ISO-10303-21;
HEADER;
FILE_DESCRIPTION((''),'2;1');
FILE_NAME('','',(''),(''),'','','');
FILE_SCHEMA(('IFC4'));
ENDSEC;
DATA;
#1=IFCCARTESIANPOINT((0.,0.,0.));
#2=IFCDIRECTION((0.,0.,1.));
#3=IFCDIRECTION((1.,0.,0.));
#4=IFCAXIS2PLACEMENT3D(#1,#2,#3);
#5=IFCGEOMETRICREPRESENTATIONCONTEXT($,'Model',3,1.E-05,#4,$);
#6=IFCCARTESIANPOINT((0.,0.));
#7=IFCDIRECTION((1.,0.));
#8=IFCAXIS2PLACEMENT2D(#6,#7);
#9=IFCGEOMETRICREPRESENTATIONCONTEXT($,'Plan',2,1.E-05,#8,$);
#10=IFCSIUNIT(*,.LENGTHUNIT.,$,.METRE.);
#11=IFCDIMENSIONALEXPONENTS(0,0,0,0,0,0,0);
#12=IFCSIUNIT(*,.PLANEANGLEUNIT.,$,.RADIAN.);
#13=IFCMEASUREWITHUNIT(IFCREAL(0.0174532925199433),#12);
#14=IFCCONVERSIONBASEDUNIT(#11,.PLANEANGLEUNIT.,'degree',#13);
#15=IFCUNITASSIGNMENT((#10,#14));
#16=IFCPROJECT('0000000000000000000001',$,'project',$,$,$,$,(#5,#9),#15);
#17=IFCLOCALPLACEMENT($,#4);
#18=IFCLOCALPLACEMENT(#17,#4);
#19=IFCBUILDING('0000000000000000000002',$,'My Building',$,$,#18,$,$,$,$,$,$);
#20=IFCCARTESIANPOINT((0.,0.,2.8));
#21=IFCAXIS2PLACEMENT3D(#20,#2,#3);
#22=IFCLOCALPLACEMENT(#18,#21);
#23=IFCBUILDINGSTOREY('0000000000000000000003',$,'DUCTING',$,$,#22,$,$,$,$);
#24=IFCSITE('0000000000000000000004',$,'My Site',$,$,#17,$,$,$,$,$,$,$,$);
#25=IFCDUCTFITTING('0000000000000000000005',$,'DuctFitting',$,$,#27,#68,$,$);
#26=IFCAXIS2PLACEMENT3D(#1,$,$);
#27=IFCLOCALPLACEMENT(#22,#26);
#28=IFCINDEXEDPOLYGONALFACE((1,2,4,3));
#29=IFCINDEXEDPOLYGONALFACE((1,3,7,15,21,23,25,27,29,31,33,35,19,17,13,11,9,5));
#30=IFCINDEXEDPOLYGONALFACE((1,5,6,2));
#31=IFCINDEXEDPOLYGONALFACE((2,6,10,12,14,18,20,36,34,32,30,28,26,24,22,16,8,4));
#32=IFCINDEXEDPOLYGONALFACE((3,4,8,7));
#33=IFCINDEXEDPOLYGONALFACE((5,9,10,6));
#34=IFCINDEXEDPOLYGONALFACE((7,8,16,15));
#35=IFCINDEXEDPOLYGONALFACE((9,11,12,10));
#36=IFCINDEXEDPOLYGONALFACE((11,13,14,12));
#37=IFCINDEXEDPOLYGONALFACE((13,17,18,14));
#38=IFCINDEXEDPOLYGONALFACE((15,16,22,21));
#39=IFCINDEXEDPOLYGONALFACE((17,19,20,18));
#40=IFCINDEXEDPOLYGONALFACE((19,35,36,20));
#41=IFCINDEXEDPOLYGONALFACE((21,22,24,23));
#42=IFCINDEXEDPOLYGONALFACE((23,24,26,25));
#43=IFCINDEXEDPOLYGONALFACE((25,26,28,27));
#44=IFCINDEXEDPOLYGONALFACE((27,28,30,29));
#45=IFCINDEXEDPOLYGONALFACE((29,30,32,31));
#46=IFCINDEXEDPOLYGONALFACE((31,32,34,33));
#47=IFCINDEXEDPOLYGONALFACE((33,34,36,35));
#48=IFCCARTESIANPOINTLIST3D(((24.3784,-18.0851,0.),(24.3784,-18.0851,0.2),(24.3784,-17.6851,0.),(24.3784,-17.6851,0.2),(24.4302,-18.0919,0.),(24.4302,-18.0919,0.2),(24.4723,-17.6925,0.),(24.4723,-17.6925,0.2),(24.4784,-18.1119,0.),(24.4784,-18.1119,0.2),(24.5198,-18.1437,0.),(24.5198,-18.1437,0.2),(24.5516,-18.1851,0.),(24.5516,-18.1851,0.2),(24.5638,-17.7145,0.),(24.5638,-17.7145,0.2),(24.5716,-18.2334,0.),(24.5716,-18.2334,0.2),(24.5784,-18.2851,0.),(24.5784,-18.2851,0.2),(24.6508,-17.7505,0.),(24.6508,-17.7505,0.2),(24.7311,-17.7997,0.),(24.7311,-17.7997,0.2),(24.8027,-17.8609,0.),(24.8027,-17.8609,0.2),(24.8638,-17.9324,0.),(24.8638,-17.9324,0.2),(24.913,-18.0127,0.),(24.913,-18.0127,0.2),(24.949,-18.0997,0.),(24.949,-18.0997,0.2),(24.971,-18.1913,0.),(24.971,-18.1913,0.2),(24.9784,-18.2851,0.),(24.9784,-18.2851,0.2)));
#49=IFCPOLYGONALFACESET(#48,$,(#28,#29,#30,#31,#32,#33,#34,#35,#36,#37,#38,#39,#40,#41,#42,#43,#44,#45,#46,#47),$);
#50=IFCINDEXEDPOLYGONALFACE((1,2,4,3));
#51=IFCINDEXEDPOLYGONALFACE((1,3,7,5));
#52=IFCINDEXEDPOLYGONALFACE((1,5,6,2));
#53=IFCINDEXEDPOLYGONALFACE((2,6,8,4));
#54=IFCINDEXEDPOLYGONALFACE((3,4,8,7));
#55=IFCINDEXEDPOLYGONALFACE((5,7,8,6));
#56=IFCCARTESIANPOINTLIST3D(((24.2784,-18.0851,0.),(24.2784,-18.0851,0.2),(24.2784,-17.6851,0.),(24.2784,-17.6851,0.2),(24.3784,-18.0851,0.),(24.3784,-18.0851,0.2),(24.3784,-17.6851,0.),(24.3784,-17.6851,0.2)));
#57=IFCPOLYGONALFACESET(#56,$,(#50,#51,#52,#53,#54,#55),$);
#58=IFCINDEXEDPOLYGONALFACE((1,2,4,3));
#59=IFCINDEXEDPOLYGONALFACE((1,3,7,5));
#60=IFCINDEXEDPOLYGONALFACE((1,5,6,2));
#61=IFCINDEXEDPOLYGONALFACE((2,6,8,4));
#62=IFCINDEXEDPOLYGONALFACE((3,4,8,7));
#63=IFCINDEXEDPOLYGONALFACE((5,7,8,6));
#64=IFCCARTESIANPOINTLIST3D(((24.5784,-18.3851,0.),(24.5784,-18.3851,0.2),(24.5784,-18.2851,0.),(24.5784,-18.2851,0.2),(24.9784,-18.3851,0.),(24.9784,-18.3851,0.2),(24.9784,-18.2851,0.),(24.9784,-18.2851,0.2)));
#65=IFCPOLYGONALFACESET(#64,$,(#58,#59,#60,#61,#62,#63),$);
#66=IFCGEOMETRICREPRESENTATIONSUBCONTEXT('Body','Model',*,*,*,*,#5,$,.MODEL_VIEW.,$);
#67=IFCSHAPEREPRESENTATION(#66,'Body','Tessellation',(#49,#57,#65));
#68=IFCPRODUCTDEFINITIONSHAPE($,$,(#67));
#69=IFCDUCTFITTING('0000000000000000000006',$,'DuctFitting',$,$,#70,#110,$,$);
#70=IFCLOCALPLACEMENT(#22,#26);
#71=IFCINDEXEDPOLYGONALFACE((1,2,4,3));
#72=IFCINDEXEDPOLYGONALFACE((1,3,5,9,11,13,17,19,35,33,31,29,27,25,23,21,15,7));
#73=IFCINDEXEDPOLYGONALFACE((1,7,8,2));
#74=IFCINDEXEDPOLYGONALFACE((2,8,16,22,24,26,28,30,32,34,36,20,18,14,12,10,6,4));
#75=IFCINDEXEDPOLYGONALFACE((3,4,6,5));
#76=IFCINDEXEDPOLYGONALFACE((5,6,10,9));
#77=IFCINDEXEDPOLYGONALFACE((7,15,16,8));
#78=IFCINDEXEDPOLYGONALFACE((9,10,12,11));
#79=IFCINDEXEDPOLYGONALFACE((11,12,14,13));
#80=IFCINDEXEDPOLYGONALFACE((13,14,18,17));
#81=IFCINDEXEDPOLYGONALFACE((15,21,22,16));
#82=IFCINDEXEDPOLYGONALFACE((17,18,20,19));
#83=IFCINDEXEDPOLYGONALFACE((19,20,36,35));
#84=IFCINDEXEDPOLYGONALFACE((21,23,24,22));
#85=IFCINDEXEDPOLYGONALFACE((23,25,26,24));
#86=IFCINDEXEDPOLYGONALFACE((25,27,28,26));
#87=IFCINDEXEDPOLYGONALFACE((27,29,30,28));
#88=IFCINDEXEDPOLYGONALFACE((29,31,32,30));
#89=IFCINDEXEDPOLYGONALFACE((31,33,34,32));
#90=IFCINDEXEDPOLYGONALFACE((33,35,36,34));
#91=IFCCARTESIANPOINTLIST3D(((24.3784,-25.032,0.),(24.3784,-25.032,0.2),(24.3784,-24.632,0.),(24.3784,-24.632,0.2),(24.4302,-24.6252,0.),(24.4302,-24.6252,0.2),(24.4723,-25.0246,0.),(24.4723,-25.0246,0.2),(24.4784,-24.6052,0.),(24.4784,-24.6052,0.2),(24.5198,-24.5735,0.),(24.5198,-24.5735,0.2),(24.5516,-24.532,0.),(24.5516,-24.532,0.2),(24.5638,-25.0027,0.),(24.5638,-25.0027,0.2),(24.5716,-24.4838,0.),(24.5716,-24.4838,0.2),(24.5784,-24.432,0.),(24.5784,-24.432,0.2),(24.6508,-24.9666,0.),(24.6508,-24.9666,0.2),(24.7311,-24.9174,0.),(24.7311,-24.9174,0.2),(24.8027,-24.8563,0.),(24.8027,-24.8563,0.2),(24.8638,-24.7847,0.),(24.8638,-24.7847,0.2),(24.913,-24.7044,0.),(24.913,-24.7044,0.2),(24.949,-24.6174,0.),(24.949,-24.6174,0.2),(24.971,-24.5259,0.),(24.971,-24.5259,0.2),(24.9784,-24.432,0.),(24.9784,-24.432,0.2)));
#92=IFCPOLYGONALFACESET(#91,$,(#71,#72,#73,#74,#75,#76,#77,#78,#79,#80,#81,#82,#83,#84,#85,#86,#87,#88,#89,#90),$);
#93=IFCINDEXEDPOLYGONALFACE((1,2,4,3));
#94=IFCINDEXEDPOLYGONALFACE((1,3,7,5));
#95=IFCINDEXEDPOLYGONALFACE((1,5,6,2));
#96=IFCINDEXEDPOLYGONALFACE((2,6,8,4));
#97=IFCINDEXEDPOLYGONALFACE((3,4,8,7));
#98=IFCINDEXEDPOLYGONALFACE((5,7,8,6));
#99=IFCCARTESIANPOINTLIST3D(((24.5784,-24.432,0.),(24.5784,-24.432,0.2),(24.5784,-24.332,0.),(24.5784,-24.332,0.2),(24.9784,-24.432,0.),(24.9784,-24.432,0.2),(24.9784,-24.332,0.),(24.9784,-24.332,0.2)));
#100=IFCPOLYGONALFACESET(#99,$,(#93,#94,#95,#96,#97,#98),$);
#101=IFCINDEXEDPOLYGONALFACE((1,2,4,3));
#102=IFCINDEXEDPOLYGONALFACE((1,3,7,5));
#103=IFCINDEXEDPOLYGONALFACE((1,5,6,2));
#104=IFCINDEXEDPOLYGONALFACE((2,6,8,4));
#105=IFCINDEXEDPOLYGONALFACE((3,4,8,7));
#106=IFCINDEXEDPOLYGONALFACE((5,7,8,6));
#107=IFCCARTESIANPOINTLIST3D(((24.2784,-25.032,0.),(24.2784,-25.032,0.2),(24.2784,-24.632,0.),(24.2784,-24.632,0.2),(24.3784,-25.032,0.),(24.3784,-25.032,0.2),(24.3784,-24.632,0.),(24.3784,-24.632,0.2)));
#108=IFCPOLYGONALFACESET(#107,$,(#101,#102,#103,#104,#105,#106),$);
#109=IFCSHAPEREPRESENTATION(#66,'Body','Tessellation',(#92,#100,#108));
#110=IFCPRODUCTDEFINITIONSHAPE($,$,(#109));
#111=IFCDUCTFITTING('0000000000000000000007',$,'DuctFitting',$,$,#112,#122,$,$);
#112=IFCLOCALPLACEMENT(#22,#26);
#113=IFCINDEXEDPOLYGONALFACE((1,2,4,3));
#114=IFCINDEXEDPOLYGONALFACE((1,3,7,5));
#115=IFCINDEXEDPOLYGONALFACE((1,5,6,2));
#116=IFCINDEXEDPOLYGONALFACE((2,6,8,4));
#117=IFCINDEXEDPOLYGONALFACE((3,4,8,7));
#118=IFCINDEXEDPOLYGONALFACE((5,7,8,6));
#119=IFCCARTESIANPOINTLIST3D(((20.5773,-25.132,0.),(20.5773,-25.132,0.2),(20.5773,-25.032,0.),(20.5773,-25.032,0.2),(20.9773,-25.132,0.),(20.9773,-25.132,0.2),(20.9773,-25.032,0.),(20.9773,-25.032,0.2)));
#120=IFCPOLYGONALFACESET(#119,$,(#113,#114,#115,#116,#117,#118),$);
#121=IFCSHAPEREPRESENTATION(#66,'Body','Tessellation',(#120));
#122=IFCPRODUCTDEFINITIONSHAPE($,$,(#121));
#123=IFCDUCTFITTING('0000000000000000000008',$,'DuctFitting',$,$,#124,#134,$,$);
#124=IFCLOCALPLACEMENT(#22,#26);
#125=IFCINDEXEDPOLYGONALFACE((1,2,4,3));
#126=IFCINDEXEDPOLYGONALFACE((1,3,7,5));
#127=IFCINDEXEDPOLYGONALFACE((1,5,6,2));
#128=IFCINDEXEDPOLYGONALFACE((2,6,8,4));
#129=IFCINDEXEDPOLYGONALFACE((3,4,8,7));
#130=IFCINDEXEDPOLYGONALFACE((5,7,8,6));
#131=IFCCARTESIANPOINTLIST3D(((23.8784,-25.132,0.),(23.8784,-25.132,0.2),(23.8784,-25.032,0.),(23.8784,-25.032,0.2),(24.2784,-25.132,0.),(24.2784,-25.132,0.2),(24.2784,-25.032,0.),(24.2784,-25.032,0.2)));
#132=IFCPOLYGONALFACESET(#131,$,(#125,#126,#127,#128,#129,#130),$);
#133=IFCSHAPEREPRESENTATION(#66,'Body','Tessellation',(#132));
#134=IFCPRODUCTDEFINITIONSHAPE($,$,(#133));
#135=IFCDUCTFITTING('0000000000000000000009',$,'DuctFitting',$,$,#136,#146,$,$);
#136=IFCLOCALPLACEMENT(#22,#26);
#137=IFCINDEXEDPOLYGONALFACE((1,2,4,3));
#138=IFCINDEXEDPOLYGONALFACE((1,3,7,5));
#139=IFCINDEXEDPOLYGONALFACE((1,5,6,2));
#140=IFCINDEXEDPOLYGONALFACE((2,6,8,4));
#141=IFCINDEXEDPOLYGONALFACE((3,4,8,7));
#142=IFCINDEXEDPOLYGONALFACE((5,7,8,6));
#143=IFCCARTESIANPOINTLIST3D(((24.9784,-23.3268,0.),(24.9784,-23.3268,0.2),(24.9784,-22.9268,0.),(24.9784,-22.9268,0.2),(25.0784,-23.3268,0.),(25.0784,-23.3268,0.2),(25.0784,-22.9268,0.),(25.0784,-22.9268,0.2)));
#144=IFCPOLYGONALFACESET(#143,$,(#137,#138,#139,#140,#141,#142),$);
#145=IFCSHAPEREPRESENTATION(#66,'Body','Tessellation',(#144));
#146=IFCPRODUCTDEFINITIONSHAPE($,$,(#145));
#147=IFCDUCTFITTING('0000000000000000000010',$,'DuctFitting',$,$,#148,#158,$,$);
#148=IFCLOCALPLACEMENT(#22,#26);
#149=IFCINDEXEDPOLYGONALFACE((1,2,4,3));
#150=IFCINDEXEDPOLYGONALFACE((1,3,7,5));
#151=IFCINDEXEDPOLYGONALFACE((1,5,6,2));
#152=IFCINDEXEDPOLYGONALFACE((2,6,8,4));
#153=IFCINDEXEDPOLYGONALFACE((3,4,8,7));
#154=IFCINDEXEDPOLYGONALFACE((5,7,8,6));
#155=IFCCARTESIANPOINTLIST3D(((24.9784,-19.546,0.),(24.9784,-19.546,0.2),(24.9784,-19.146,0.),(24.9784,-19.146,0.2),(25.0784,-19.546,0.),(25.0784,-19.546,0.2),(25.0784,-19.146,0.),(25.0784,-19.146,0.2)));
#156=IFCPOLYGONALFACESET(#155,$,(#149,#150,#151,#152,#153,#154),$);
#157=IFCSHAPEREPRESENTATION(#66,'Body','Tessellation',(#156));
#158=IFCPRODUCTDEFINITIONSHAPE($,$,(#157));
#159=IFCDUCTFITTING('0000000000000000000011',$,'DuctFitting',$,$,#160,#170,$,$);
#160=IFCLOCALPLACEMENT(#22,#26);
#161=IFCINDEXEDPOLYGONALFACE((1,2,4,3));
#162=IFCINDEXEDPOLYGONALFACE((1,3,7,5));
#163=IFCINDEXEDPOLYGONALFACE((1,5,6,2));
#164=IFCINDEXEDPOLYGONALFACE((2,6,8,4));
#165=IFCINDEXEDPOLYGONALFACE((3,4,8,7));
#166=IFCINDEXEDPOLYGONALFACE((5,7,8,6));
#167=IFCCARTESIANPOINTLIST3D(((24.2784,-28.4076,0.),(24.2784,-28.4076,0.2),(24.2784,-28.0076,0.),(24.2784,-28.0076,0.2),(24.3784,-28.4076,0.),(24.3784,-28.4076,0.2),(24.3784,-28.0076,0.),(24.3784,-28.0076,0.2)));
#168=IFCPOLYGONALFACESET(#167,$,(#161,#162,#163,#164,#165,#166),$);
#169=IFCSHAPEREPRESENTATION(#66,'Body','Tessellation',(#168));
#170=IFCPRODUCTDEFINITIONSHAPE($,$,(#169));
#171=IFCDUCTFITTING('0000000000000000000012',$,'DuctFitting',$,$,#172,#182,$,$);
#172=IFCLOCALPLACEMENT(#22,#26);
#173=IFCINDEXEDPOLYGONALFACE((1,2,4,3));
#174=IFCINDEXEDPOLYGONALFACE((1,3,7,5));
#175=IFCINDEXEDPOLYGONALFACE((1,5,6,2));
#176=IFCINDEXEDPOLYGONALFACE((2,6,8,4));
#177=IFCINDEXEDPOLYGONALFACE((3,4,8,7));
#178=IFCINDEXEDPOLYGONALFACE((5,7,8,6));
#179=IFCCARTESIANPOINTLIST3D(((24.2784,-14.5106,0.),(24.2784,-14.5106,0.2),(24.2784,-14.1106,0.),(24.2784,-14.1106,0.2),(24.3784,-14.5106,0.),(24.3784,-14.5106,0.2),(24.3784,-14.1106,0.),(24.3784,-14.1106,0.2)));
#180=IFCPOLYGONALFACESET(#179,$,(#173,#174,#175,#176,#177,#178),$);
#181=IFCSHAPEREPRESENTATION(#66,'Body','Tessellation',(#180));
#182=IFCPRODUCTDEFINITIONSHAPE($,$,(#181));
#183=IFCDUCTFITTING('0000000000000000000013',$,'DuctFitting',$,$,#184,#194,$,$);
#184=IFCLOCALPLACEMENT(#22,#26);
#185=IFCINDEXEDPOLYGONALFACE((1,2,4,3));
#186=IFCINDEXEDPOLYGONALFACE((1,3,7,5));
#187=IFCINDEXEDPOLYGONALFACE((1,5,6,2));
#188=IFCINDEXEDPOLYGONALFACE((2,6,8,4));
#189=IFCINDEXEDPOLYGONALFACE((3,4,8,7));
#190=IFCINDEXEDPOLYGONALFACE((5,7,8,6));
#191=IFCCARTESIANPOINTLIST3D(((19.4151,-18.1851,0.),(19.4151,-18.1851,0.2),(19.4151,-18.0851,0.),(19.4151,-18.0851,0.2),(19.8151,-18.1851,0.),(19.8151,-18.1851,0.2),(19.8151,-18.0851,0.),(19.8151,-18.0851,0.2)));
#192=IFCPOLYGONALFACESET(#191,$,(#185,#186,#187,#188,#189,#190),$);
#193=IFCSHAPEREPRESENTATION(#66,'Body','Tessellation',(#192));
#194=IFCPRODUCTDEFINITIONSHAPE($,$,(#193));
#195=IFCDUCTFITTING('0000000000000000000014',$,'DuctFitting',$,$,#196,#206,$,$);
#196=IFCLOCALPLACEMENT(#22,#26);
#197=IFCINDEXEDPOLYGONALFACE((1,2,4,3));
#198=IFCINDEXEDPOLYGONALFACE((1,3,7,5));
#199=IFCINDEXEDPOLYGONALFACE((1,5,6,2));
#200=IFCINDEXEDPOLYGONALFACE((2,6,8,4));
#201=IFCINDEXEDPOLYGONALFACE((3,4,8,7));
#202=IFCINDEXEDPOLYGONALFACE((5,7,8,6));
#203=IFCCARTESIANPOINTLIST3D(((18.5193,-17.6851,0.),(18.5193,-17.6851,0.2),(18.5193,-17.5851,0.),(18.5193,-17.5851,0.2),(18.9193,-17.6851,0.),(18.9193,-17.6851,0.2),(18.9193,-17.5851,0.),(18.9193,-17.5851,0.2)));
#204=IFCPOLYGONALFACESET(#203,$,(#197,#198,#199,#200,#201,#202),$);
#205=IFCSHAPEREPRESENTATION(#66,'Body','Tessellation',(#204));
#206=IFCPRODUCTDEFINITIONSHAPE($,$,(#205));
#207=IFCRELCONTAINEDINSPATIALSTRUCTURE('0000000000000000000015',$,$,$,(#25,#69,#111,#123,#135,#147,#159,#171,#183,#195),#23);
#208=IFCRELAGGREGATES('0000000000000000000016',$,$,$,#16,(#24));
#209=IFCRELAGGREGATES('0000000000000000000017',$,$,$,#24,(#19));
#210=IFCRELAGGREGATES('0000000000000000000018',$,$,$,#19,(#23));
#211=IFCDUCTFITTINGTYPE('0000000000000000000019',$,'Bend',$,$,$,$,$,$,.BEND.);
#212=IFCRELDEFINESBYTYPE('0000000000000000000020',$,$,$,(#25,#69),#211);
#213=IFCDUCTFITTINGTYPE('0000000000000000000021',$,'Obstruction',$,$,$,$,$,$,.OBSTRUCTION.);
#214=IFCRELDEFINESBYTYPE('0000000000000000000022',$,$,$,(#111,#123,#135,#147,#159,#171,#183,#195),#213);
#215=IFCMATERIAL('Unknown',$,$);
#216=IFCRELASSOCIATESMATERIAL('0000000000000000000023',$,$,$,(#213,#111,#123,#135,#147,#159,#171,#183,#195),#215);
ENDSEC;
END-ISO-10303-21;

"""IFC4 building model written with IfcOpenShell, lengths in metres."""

from ifc_helpers import new_model, entity, si_unit, converted_unit, frame, origin_with_axes, origin_2d_with_axis, place, context, subcontext, project, spatial, line, arc, indexed_curve, rectangle, outline, extrude, source, transform, mapped, material, material_profile, profile_set, profile_usage, type_object, type_shapes, element, save


model = new_model("IFC4")

# Units and contexts
model_context = context("Model", 3, precision=1e-05, world=origin_with_axes())
plan_context = context("Plan", 2, precision=1e-05, world=origin_2d_with_axis())
body_context = subcontext(model_context, "Body", "Model", "MODEL_VIEW")
ifc_project = project(units=[si_unit("LENGTHUNIT", "METRE"), converted_unit("PLANEANGLEUNIT", "degree", entity("IfcReal", 0.0174532925199433), si_unit("PLANEANGLEUNIT", "RADIAN"), dimensions=[0, 0, 0, 0, 0, 0, 0])], contexts=[model_context, plan_context])

# Site, building, storey
site_placement = place(None, origin_with_axes())
site = spatial("IfcSite", under=ifc_project, at=site_placement, Name="My Site")
building_placement = place(site_placement, origin_with_axes())
building = spatial("IfcBuilding", under=site, at=building_placement, Name="My Building")
storey_placement = place(building_placement, frame((0.0, 0.0, 2.8), z_axis=(0.0, 0.0, 1.0), x_axis=(1.0, 0.0, 0.0)))
storey = spatial("IfcBuildingStorey", under=building, at=storey_placement, Name="DUCTING")

# Shared definitions
ifc_material = material(Name="Unknown")

# Duct fittings
duct_fitting_type_1 = type_object("IfcDuctFittingType", Name="Bend", PredefinedType="BEND")
shared_shape = source(origin_with_axes(), body_context, "Body", "SweptSolid", [
    extrude(outline(indexed_curve([(0.2, 0.0), (0.2586, -0.1414), (0.4, -0.2), (0.4, -0.6), (-0.0243, -0.4243), (-0.2, 0.0)], segments=[arc(1, 2, 3), line(3, 4), arc(4, 5, 6), line(6, 1)])), frame((0.0, -0.1, -0.1), z_axis=(0.0, -1.0, 0.0), x_axis=(1.0, 0.0, 0.0)), (0.0, 0.0, -1.0), 0.2),
    extrude(rectangle(XDim=0.4, YDim=0.2), origin_with_axes(), (0.0, 0.0, -1.0), 0.1),
    extrude(rectangle(XDim=0.4, YDim=0.2), frame((0.4, 0.0, -0.5), z_axis=(1.0, 0.0, 0.0), x_axis=(0.0, 0.0, 1.0)), (0.0, 0.0, 1.0), 0.1),
])
type_shapes(duct_fitting_type_1, [shared_shape])
for number, where, z_axis, x_axis, name in (
    (1, (24.2784, -17.8851, 0.1), (-1.0, 0.0, 0.000001), (0.0, -1.0, 0.0), "DuctFitting"),
    (2, (24.7784, -24.332, 0.1), (0.0, 1.0, 0.0), (-1.0, 0.0, 0.0), "DuctFitting"),
):
    element("IfcDuctFitting", number, at=place(storey_placement, frame(where, z_axis=z_axis, x_axis=x_axis)), inside=storey, type_object=duct_fitting_type_1, Name=name, context=body_context, shape_type="MappedRepresentation", body=[
        mapped(shared_shape, transform((0.0, 0.0, 0.0), x_axis=(1.0, 0.0, 0.0), y_axis=(0.0, 1.0, 0.0), z_axis=(0.0, 0.0, 1.0), scale=1.0)),
    ])
ifc_material_profile_1 = material_profile(ifc_material, rectangle(XDim=0.4, YDim=0.2))
ifc_profile_set_1 = profile_set([ifc_material_profile_1])
ifc_profile_usage_1 = profile_usage(ifc_profile_set_1, cardinal=5)
duct_fitting_type_2 = type_object("IfcDuctFittingType", Name="Obstruction", PredefinedType="OBSTRUCTION", material=ifc_profile_set_1)
duct_fitting_1_placement = place(storey_placement, frame((20.7773, -25.032, 0.1), z_axis=(0.0, -1.0, 0.0), x_axis=(1.0, 0.0, 0.0)))
element("IfcDuctFitting", 3, at=duct_fitting_1_placement, inside=storey, type_object=duct_fitting_type_2, material=ifc_profile_usage_1, Name="DuctFitting", context=body_context, shape_type="SweptSolid", body=[
    extrude(rectangle(XDim=0.4, YDim=0.2), origin_with_axes(), (0.0, 0.0, 1.0), 0.1),
])
ifc_profile_usage_2 = profile_usage(ifc_profile_set_1, cardinal=5)
duct_fitting_2_placement = place(storey_placement, frame((24.0784, -25.032, 0.1), z_axis=(0.0, -1.0, 0.0), x_axis=(1.0, 0.0, 0.0)))
element("IfcDuctFitting", 4, at=duct_fitting_2_placement, inside=storey, type_object=duct_fitting_type_2, material=ifc_profile_usage_2, Name="DuctFitting", context=body_context, shape_type="SweptSolid", body=[
    extrude(rectangle(XDim=0.4, YDim=0.2), origin_with_axes(), (0.0, 0.0, 1.0), 0.1),
])
ifc_profile_usage_3 = profile_usage(ifc_profile_set_1, cardinal=5)
duct_fitting_3_placement = place(storey_placement, frame((24.9784, -23.1268, 0.1), z_axis=(1.0, 0.0, 0.0), x_axis=(0.0, 1.0, 0.0)))
element("IfcDuctFitting", 5, at=duct_fitting_3_placement, inside=storey, type_object=duct_fitting_type_2, material=ifc_profile_usage_3, Name="DuctFitting", context=body_context, shape_type="SweptSolid", body=[
    extrude(rectangle(XDim=0.4, YDim=0.2), origin_with_axes(), (0.0, 0.0, 1.0), 0.1),
])
ifc_profile_usage_4 = profile_usage(ifc_profile_set_1, cardinal=5)
duct_fitting_4_placement = place(storey_placement, frame((24.9784, -19.346, 0.1), z_axis=(1.0, 0.0, 0.0), x_axis=(0.0, 1.0, 0.0)))
element("IfcDuctFitting", 6, at=duct_fitting_4_placement, inside=storey, type_object=duct_fitting_type_2, material=ifc_profile_usage_4, Name="DuctFitting", context=body_context, shape_type="SweptSolid", body=[
    extrude(rectangle(XDim=0.4, YDim=0.2), origin_with_axes(), (0.0, 0.0, 1.0), 0.1),
])
ifc_profile_usage_5 = profile_usage(ifc_profile_set_1, cardinal=5)
duct_fitting_5_placement = place(storey_placement, frame((24.2784, -28.2076, 0.1), z_axis=(1.0, 0.0, 0.0), x_axis=(0.0, 1.0, 0.0)))
element("IfcDuctFitting", 7, at=duct_fitting_5_placement, inside=storey, type_object=duct_fitting_type_2, material=ifc_profile_usage_5, Name="DuctFitting", context=body_context, shape_type="SweptSolid", body=[
    extrude(rectangle(XDim=0.4, YDim=0.2), origin_with_axes(), (0.0, 0.0, 1.0), 0.1),
])
ifc_profile_usage_6 = profile_usage(ifc_profile_set_1, cardinal=5)
duct_fitting_6_placement = place(storey_placement, frame((24.2784, -14.3106, 0.1), z_axis=(1.0, 0.0, 0.0), x_axis=(0.0, 1.0, 0.0)))
element("IfcDuctFitting", 8, at=duct_fitting_6_placement, inside=storey, type_object=duct_fitting_type_2, material=ifc_profile_usage_6, Name="DuctFitting", context=body_context, shape_type="SweptSolid", body=[
    extrude(rectangle(XDim=0.4, YDim=0.2), origin_with_axes(), (0.0, 0.0, 1.0), 0.1),
])
ifc_profile_usage_7 = profile_usage(ifc_profile_set_1, cardinal=5)
duct_fitting_7_placement = place(storey_placement, frame((19.6151, -18.0851, 0.1), z_axis=(0.0, -1.0, 0.0), x_axis=(1.0, 0.0, 0.0)))
element("IfcDuctFitting", 9, at=duct_fitting_7_placement, inside=storey, type_object=duct_fitting_type_2, material=ifc_profile_usage_7, Name="DuctFitting", context=body_context, shape_type="SweptSolid", body=[
    extrude(rectangle(XDim=0.4, YDim=0.2), origin_with_axes(), (0.0, 0.0, 1.0), 0.1),
])
ifc_profile_usage_8 = profile_usage(ifc_profile_set_1, cardinal=5)
duct_fitting_8_placement = place(storey_placement, frame((18.7193, -17.6851, 0.1), z_axis=(0.0, 1.0, 0.0), x_axis=(-1.0, 0.0, 0.0)))
element("IfcDuctFitting", 10, at=duct_fitting_8_placement, inside=storey, type_object=duct_fitting_type_2, material=ifc_profile_usage_8, Name="DuctFitting", context=body_context, shape_type="SweptSolid", body=[
    extrude(rectangle(XDim=0.4, YDim=0.2), origin_with_axes(), (0.0, 0.0, 1.0), 0.1),
])

save(model, "model.ifc")
